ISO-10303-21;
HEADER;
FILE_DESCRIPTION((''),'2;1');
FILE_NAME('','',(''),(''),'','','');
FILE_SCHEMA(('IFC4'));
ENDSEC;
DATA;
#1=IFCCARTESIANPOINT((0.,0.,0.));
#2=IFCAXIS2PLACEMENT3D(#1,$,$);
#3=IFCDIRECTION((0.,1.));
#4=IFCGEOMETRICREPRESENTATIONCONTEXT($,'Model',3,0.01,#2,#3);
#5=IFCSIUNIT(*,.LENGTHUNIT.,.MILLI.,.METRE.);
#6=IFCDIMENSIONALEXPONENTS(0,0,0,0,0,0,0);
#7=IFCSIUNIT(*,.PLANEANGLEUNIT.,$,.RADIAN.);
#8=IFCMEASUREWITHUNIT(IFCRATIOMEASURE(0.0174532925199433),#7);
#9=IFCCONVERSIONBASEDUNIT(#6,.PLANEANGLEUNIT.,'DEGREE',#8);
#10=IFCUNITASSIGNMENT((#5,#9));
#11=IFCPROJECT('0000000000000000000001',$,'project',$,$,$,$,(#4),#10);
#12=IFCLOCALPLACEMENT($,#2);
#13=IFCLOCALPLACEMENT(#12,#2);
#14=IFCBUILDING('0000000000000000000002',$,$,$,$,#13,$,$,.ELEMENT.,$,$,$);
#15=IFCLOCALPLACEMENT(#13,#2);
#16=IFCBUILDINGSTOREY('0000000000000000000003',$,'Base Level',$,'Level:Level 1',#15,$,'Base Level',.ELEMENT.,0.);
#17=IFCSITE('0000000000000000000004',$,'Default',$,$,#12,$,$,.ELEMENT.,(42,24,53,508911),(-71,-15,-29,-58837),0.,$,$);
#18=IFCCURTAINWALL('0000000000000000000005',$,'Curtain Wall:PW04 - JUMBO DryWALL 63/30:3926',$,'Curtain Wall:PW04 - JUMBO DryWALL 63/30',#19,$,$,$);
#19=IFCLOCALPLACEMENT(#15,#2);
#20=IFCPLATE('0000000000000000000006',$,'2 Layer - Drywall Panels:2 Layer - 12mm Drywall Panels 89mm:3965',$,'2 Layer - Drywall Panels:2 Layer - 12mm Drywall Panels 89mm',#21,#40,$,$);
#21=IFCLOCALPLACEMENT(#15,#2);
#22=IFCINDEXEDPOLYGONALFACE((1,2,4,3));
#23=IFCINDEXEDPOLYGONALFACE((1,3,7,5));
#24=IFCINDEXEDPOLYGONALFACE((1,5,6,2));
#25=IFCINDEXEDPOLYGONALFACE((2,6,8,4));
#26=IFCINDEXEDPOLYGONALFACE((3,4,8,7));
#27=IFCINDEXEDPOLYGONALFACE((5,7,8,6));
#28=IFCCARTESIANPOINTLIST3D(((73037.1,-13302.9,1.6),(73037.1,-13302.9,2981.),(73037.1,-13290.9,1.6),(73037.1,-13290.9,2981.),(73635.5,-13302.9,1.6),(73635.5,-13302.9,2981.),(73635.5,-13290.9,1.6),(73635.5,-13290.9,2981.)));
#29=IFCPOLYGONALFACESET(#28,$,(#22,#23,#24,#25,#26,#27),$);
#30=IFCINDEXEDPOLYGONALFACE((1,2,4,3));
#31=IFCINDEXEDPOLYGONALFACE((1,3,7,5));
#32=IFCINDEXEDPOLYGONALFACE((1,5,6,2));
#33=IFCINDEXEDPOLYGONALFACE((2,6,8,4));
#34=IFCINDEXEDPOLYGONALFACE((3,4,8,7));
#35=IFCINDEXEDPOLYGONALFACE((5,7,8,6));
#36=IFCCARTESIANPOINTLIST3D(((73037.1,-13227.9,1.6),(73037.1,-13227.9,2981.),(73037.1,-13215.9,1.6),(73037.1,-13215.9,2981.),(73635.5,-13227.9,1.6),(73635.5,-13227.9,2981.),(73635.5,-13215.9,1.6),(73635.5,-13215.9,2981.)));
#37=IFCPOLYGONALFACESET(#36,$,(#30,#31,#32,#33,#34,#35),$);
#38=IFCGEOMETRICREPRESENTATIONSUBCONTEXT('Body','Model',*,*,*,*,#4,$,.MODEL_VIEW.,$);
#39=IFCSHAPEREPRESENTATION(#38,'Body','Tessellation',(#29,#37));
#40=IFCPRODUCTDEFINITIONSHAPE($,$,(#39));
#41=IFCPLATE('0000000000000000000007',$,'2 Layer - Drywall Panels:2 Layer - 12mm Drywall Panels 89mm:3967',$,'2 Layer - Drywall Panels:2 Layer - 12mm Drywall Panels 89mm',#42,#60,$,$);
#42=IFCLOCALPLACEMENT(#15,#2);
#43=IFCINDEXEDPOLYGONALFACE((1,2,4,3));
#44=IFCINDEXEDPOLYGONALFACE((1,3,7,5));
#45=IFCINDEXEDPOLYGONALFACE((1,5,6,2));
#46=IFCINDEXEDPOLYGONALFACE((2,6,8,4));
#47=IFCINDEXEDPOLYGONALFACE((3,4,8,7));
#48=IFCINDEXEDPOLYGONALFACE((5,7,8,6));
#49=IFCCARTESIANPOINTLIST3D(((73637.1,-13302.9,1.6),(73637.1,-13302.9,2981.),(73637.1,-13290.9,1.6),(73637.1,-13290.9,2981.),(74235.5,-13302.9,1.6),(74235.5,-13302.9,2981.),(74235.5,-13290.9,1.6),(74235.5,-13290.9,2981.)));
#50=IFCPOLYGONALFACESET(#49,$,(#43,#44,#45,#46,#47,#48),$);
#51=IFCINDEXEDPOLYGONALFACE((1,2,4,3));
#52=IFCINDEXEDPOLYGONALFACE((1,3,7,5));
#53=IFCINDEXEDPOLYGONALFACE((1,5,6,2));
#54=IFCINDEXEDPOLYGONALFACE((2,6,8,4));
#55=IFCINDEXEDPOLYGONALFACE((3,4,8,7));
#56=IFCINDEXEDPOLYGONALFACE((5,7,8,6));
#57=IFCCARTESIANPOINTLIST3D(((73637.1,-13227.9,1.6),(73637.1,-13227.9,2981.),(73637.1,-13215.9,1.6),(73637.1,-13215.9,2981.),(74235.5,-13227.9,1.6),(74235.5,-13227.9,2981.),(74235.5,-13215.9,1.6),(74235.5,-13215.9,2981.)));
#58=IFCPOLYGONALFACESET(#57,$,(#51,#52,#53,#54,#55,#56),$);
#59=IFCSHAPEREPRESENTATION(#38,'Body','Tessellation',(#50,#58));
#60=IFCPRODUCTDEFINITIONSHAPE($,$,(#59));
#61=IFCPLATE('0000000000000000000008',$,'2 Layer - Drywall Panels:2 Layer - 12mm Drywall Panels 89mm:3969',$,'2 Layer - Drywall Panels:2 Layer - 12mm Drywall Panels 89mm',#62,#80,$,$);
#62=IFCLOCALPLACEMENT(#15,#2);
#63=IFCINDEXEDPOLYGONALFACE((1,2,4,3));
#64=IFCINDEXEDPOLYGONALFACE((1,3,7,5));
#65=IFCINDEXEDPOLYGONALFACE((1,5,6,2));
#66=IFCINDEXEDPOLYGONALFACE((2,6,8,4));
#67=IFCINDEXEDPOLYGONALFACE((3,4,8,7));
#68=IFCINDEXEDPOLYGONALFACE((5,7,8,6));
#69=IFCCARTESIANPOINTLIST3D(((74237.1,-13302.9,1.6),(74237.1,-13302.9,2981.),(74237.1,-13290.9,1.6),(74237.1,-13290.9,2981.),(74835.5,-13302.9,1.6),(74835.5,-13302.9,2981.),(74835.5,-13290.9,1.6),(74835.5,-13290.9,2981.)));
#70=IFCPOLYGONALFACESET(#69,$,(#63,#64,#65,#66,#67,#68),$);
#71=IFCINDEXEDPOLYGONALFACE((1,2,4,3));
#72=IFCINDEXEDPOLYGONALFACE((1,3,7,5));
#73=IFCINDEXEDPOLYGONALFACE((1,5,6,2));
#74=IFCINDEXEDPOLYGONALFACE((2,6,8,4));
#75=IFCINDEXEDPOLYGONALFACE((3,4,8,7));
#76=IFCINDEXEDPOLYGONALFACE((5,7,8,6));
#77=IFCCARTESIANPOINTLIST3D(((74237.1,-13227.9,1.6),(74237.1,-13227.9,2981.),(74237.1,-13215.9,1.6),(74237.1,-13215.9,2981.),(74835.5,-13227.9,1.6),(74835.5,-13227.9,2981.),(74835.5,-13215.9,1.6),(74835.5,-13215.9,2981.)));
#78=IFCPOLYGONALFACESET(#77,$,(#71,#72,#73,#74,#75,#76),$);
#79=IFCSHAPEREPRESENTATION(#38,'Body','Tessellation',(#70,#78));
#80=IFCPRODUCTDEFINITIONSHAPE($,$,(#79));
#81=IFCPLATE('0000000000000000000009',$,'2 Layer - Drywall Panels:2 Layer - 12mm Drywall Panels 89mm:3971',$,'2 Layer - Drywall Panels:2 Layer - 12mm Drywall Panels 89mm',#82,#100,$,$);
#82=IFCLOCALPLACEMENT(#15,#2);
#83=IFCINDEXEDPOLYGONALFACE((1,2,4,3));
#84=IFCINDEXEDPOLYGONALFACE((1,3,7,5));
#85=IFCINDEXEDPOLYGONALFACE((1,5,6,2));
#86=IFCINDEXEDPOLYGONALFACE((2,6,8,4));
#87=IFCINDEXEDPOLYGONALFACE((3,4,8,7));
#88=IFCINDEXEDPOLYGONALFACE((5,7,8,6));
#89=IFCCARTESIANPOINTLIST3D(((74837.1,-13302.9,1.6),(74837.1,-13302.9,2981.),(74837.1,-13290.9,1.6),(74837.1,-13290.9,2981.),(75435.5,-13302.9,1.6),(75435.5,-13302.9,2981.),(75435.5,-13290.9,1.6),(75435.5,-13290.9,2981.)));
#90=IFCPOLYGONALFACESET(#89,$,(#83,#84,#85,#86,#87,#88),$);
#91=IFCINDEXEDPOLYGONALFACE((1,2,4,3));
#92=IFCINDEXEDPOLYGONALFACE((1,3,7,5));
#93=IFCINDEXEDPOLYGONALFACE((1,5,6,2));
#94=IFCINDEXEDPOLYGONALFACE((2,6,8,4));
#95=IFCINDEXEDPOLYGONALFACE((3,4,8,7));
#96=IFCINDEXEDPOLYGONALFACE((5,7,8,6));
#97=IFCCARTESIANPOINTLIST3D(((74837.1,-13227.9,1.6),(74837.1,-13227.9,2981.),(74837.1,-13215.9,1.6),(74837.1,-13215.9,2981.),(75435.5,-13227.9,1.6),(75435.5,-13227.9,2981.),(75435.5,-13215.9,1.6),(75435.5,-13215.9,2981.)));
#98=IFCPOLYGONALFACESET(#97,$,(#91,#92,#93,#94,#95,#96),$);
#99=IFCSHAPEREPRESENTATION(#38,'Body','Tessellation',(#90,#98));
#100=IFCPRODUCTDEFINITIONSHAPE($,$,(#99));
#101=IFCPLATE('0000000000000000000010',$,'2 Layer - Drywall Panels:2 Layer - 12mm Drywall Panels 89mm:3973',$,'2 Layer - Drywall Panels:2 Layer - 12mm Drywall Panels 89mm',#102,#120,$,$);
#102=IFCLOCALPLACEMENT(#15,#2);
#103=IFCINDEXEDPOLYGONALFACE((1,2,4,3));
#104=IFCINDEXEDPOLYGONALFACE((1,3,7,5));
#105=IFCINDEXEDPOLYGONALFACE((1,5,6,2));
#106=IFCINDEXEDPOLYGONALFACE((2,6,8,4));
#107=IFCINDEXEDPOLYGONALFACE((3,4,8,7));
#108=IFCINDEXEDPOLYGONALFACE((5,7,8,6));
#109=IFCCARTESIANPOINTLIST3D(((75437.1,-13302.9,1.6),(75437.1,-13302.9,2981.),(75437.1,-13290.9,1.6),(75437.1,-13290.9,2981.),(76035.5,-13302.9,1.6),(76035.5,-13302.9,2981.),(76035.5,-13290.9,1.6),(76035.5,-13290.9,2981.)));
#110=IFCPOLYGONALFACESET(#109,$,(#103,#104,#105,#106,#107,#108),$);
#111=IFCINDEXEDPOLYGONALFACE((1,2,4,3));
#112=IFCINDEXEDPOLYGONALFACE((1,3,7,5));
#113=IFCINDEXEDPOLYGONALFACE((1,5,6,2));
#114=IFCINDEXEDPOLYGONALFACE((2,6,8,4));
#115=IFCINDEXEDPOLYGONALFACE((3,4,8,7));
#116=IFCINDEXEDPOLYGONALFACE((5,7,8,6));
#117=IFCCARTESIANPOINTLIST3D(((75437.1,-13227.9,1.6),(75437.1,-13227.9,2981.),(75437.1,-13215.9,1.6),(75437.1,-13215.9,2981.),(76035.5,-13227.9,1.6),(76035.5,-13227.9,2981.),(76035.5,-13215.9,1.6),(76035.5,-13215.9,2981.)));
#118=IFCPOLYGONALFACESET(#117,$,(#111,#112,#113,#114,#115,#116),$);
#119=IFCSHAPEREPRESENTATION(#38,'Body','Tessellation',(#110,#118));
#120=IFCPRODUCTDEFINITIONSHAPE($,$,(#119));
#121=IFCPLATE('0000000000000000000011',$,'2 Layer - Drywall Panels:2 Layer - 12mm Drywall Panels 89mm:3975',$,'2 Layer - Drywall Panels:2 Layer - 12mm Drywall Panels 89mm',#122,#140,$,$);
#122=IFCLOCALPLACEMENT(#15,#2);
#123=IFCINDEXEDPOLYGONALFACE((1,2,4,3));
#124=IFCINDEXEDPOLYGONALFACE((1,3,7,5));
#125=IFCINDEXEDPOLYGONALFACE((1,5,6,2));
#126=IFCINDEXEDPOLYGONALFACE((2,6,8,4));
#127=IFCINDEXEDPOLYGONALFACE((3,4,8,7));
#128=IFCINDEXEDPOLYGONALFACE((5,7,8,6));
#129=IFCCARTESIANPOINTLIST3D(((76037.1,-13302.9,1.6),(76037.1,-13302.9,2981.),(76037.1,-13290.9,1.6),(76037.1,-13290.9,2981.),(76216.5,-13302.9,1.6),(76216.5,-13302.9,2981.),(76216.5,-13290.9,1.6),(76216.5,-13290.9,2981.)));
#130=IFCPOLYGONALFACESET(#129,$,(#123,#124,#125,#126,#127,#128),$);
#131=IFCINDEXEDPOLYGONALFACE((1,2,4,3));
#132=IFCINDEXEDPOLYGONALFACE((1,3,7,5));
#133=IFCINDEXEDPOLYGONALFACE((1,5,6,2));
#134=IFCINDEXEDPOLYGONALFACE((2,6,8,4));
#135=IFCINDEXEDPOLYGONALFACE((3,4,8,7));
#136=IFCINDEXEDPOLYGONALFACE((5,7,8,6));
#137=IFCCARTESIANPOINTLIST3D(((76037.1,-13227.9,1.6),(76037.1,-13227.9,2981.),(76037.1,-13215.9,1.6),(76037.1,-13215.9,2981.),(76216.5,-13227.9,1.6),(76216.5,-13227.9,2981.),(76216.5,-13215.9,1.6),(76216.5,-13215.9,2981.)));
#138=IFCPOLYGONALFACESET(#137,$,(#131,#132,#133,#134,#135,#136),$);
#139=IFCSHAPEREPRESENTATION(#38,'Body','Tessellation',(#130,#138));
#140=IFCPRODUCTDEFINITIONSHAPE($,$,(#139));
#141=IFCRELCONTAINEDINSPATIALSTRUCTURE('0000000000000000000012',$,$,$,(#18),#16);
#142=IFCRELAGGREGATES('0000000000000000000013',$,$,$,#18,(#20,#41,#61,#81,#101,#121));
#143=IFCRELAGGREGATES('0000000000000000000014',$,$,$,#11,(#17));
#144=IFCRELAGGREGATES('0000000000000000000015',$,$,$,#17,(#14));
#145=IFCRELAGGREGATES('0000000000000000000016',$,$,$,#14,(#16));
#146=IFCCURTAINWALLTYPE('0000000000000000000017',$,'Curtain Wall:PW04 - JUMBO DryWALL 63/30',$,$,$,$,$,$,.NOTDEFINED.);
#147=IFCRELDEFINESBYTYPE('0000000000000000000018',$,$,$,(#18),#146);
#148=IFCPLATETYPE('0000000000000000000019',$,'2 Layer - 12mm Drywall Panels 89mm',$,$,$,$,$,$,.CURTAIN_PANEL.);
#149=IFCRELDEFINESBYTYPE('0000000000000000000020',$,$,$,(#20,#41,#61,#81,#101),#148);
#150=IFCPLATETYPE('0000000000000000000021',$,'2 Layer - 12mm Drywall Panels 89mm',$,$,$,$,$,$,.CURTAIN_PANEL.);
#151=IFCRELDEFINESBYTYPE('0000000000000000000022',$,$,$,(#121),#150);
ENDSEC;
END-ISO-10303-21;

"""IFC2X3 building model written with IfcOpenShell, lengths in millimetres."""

from ifc_helpers import new_model, entity, si_unit, converted_unit, direction, frame, frame_2d, origin, place, context, subcontext, project, spatial, rectangle, extrude, source, transform, mapped, type_object, type_shapes, element, aggregate, save


model = new_model("IFC2X3")

# Units and contexts
model_context = context("Model", 3, precision=0.01, world=origin(), true_north=direction((0.0, 1.0)))
body_context = subcontext(model_context, "Body", "Model", "MODEL_VIEW")
ifc_project = project(units=[si_unit("LENGTHUNIT", "METRE", prefix="MILLI"), converted_unit("PLANEANGLEUNIT", "DEGREE", entity("IfcRatioMeasure", 0.0174532925199433), si_unit("PLANEANGLEUNIT", "RADIAN"), dimensions=[0, 0, 0, 0, 0, 0, 0])], contexts=[model_context])

# Site, building, storey
site_placement = place(None, origin())
site = spatial("IfcSite", under=ifc_project, at=site_placement, Name="Default", CompositionType="ELEMENT", RefLatitude=(42, 24, 53, 508911), RefLongitude=(-71, -15, -29, -58837), RefElevation=0.0)
building_placement = place(site_placement, origin())
building = spatial("IfcBuilding", under=site, at=building_placement, CompositionType="ELEMENT")
storey_placement = place(building_placement, origin())
storey = spatial("IfcBuildingStorey", under=building, at=storey_placement, Name="Base Level", ObjectType="Level:Level 1", LongName="Base Level", CompositionType="ELEMENT", Elevation=0.0)

# Curtain wall, plates
curtain_wall_type = type_object("IfcCurtainWallType", Name="Curtain Wall:PW04 - JUMBO DryWALL 63/30", PredefinedType="NOTDEFINED")
curtain_wall_placement = place(building_placement, origin())
curtain_wall = element("IfcCurtainWall", 1, at=curtain_wall_placement, inside=storey, type_object=curtain_wall_type, Name="Curtain Wall:PW04 - JUMBO DryWALL 63/30:3926", ObjectType="Curtain Wall:PW04 - JUMBO DryWALL 63/30")
plate_type_1 = type_object("IfcPlateType", Name="2 Layer - 12mm Drywall Panels 89mm", PredefinedType="CURTAIN_PANEL")
shared_shape_1 = source(origin(), body_context, "Body", "SweptSolid", [
    extrude(rectangle(XDim=598.4, YDim=12.0, at=frame_2d((0.0, 0.0), x_axis=(1.0, 0.0))), frame((0.0, -37.5, 0.0), z_axis=(0.0, 0.0, 1.0), x_axis=(-1.0, 0.0, 0.0)), (0.0, 0.0, 1.0), 2979.4),
    extrude(rectangle(XDim=12.0, YDim=598.4, at=frame_2d((0.0, 0.0), x_axis=(1.0, 0.0))), frame((0.0, 37.5, 0.0), z_axis=(0.0, 0.0, 1.0), x_axis=(0.0, 1.0, 0.0)), (0.0, 0.0, 1.0), 2979.4),
])
type_shapes(plate_type_1, [shared_shape_1])
plate_1_placement = place(curtain_wall_placement, frame((73336.3, -13259.4, 1.6)))
plate_1 = element("IfcPlate", 2, at=plate_1_placement, type_object=plate_type_1, Name="2 Layer - Drywall Panels:2 Layer - 12mm Drywall Panels 89mm:3965", ObjectType="2 Layer - Drywall Panels:2 Layer - 12mm Drywall Panels 89mm", context=body_context, shape_type="MappedRepresentation", body=[
    mapped(shared_shape_1, transform((0.0, 0.0, 0.0), scale=1.0)),
])
plate_2_placement = place(curtain_wall_placement, frame((73936.3, -13259.4, 1.6)))
plate_2 = element("IfcPlate", 3, at=plate_2_placement, type_object=plate_type_1, Name="2 Layer - Drywall Panels:2 Layer - 12mm Drywall Panels 89mm:3967", ObjectType="2 Layer - Drywall Panels:2 Layer - 12mm Drywall Panels 89mm", context=body_context, shape_type="MappedRepresentation", body=[
    mapped(shared_shape_1, transform((0.0, 0.0, 0.0), scale=1.0)),
])
plate_3_placement = place(curtain_wall_placement, frame((74536.3, -13259.4, 1.6)))
plate_3 = element("IfcPlate", 4, at=plate_3_placement, type_object=plate_type_1, Name="2 Layer - Drywall Panels:2 Layer - 12mm Drywall Panels 89mm:3969", ObjectType="2 Layer - Drywall Panels:2 Layer - 12mm Drywall Panels 89mm", context=body_context, shape_type="MappedRepresentation", body=[
    mapped(shared_shape_1, transform((0.0, 0.0, 0.0), scale=1.0)),
])
plate_4_placement = place(curtain_wall_placement, frame((75136.3, -13259.4, 1.6)))
plate_4 = element("IfcPlate", 5, at=plate_4_placement, type_object=plate_type_1, Name="2 Layer - Drywall Panels:2 Layer - 12mm Drywall Panels 89mm:3971", ObjectType="2 Layer - Drywall Panels:2 Layer - 12mm Drywall Panels 89mm", context=body_context, shape_type="MappedRepresentation", body=[
    mapped(shared_shape_1, transform((0.0, 0.0, 0.0), scale=1.0)),
])
plate_5_placement = place(curtain_wall_placement, frame((75736.3, -13259.4, 1.6)))
plate_5 = element("IfcPlate", 6, at=plate_5_placement, type_object=plate_type_1, Name="2 Layer - Drywall Panels:2 Layer - 12mm Drywall Panels 89mm:3973", ObjectType="2 Layer - Drywall Panels:2 Layer - 12mm Drywall Panels 89mm", context=body_context, shape_type="MappedRepresentation", body=[
    mapped(shared_shape_1, transform((0.0, 0.0, 0.0), scale=1.0)),
])
plate_type_2 = type_object("IfcPlateType", Name="2 Layer - 12mm Drywall Panels 89mm", PredefinedType="CURTAIN_PANEL")
shared_shape_2 = source(origin(), body_context, "Body", "SweptSolid", [
    extrude(rectangle(XDim=179.4, YDim=12.0, at=frame_2d((0.0, 0.0), x_axis=(1.0, 0.0))), frame((0.0, -37.5, 0.0), z_axis=(0.0, 0.0, 1.0), x_axis=(-1.0, 0.0, 0.0)), (0.0, 0.0, 1.0), 2979.4),
    extrude(rectangle(XDim=12.0, YDim=179.4, at=frame_2d((0.0, 0.0), x_axis=(1.0, 0.0))), frame((0.0, 37.5, 0.0), z_axis=(0.0, 0.0, 1.0), x_axis=(0.0, 1.0, 0.0)), (0.0, 0.0, 1.0), 2979.4),
])
type_shapes(plate_type_2, [shared_shape_2])
plate_6_placement = place(curtain_wall_placement, frame((76126.8, -13259.4, 1.6)))
plate_6 = element("IfcPlate", 7, at=plate_6_placement, type_object=plate_type_2, Name="2 Layer - Drywall Panels:2 Layer - 12mm Drywall Panels 89mm:3975", ObjectType="2 Layer - Drywall Panels:2 Layer - 12mm Drywall Panels 89mm", context=body_context, shape_type="MappedRepresentation", body=[
    mapped(shared_shape_2, transform((0.0, 0.0, 0.0), scale=1.0)),
])
aggregate(curtain_wall, [plate_1, plate_2, plate_3, plate_4, plate_5, plate_6])

save(model, "model.ifc")
